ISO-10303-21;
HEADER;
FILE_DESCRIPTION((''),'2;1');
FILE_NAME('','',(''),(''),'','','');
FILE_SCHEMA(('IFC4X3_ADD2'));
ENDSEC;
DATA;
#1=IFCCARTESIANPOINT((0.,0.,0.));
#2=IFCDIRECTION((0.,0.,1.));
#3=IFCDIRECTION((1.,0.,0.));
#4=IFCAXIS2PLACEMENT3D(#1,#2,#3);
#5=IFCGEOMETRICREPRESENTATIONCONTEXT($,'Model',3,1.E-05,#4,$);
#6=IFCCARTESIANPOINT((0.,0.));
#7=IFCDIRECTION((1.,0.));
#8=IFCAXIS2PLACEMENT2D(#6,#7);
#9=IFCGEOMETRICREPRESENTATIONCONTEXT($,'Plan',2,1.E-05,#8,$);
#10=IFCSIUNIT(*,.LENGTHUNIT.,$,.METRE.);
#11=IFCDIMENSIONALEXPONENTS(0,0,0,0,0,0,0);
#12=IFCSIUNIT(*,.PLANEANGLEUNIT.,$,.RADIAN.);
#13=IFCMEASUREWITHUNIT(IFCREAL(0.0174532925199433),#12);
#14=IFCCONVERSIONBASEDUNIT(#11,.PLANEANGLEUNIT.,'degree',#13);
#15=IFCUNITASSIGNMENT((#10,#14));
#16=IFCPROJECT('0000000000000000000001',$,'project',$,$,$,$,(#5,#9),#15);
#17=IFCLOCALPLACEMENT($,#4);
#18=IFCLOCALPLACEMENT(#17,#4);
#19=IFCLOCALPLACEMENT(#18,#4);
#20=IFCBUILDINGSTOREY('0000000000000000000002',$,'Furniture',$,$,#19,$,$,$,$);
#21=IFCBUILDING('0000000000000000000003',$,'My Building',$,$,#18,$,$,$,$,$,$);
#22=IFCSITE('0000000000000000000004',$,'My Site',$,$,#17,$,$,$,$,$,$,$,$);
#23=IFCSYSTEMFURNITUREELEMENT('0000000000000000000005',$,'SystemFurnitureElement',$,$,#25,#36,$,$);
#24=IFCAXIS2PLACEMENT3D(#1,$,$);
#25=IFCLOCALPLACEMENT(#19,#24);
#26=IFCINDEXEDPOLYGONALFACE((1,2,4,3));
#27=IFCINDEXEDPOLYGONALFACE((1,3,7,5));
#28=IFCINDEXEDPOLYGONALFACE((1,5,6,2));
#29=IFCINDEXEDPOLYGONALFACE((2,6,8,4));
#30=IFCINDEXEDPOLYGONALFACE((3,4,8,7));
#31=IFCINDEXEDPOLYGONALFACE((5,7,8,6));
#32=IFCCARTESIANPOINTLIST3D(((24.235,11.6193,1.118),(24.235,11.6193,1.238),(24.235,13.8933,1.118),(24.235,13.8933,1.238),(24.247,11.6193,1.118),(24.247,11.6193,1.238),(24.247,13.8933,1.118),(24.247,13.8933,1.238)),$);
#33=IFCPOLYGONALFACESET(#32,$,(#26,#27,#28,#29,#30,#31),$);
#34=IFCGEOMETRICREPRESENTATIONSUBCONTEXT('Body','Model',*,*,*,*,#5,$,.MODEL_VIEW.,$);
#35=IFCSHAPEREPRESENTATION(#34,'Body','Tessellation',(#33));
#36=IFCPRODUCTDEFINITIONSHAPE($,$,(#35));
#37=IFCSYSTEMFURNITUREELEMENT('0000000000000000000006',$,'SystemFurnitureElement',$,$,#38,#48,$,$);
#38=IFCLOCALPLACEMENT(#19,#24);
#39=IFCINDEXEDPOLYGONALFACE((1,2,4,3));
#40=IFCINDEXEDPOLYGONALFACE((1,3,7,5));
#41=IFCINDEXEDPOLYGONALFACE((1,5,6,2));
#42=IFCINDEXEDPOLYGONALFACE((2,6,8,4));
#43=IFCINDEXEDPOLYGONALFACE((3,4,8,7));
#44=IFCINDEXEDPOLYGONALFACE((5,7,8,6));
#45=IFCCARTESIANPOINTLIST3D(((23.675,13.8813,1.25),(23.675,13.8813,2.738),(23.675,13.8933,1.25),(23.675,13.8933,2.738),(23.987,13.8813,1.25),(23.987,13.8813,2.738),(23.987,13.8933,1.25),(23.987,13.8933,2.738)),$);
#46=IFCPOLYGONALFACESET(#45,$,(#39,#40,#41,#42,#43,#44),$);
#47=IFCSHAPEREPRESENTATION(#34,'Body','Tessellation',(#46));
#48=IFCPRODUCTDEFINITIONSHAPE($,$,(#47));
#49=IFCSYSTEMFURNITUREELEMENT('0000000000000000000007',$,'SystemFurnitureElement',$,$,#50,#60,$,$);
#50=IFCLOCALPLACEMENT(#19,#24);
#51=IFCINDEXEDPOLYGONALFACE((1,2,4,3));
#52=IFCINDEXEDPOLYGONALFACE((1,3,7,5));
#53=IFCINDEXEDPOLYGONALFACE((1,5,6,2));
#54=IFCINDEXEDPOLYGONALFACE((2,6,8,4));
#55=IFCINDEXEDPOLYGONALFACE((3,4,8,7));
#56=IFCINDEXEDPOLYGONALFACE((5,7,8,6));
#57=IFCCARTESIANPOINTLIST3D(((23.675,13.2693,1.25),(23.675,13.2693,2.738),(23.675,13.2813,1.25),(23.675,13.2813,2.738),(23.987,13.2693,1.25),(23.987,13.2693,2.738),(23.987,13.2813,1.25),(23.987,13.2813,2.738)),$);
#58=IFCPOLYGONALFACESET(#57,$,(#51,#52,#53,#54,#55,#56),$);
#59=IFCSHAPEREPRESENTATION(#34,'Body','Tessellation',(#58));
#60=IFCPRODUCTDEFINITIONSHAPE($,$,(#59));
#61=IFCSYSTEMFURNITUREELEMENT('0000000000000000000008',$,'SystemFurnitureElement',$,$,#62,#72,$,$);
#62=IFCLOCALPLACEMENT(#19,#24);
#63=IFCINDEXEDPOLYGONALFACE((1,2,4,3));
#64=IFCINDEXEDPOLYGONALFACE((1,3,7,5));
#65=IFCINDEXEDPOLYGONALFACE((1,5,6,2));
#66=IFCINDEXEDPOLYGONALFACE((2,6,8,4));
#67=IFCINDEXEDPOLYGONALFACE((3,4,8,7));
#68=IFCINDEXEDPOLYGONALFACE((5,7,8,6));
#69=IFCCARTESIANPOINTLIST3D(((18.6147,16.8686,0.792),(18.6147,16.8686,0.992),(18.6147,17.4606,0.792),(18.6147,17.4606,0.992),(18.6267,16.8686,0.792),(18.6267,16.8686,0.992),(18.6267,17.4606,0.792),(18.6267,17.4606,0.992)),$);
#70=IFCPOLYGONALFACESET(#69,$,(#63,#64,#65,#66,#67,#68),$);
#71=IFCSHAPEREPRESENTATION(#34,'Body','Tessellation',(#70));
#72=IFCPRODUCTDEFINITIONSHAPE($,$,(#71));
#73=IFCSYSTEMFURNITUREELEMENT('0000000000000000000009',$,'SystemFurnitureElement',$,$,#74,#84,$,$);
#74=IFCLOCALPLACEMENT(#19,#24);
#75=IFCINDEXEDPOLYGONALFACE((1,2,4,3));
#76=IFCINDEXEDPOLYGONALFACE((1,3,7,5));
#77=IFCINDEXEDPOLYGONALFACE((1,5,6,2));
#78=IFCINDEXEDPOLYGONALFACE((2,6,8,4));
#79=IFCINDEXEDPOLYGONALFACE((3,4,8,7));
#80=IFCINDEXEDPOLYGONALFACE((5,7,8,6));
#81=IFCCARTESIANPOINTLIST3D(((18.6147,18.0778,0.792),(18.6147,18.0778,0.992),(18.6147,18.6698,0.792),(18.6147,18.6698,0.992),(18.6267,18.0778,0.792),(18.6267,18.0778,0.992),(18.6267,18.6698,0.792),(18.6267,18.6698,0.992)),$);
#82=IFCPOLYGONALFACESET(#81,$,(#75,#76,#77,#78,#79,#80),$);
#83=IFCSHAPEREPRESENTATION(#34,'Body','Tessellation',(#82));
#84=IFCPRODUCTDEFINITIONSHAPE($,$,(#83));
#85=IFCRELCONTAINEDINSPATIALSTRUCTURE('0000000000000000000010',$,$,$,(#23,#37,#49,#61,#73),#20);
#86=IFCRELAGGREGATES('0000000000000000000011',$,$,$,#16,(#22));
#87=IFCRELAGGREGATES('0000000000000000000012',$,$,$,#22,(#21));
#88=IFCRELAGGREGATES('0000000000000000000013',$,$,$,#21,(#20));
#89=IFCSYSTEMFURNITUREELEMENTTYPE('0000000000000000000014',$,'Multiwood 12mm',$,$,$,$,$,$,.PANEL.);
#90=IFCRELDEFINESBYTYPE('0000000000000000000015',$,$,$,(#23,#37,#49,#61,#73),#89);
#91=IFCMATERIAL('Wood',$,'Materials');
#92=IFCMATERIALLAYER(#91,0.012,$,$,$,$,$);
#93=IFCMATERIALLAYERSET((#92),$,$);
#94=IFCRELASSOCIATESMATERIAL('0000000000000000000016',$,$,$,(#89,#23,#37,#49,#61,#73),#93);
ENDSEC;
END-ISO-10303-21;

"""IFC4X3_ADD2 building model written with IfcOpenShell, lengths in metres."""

from ifc_helpers import new_model, entity, si_unit, converted_unit, frame, origin_with_axes, origin_2d_with_axis, place, context, subcontext, project, spatial, line, indexed_curve, outline, extrude, material, layer, layer_set, layer_usage, type_object, element, save


model = new_model("IFC4X3_ADD2")

# Units and contexts
model_context = context("Model", 3, precision=1e-05, world=origin_with_axes())
plan_context = context("Plan", 2, precision=1e-05, world=origin_2d_with_axis())
body_context = subcontext(model_context, "Body", "Model", "MODEL_VIEW")
ifc_project = project(units=[si_unit("LENGTHUNIT", "METRE"), converted_unit("PLANEANGLEUNIT", "degree", entity("IfcReal", 0.0174532925199433), si_unit("PLANEANGLEUNIT", "RADIAN"), dimensions=[0, 0, 0, 0, 0, 0, 0])], contexts=[model_context, plan_context])

# Site, building, storey
site_placement = place(None, origin_with_axes())
site = spatial("IfcSite", under=ifc_project, at=site_placement, Name="My Site")
building_placement = place(site_placement, origin_with_axes())
building = spatial("IfcBuilding", under=site, at=building_placement, Name="My Building")
storey_placement = place(building_placement, origin_with_axes())
storey = spatial("IfcBuildingStorey", under=building, at=storey_placement, Name="Furniture")

# System furniture elements
ifc_material = material(Name="Wood", Category="Materials")
ifc_layer_1 = layer(ifc_material, 0.012)
ifc_layer_set_1 = layer_set([ifc_layer_1])
ifc_layer_usage_1 = layer_usage(ifc_layer_set_1, "AXIS2", "POSITIVE", 0.0)
system_furniture_element_type_1 = type_object("IfcSystemFurnitureElementType", Name="Multiwood 12mm", PredefinedType="PANEL", material=ifc_layer_set_1)
system_furniture_element_1_placement = place(storey_placement, frame((24.247, 11.6193, 1.118), z_axis=(0.0, 0.0, 1.0), x_axis=(0.000001, 1.0, 0.0)))
element("IfcSystemFurnitureElement", 1, at=system_furniture_element_1_placement, inside=storey, type_object=system_furniture_element_type_1, material=ifc_layer_usage_1, Name="SystemFurnitureElement", context=body_context, shape_type="SweptSolid", body=[
    extrude(outline(indexed_curve([(0.0, 0.0), (0.0, 0.012), (2.274, 0.012), (2.274, 0.0)], segments=[line(1, 2, 3, 4, 1)])), origin_with_axes(), (0.0, 0.0, 1.0), 0.12),
])
ifc_layer_usage_2 = layer_usage(ifc_layer_set_1, "AXIS2", "POSITIVE", 0.0)
system_furniture_element_2_placement = place(storey_placement, frame((23.675, 13.8813, 1.25), z_axis=(0.0, 0.0, 1.0), x_axis=(1.0, -0.000001, 0.0)))
element("IfcSystemFurnitureElement", 2, at=system_furniture_element_2_placement, inside=storey, type_object=system_furniture_element_type_1, material=ifc_layer_usage_2, Name="SystemFurnitureElement", context=body_context, shape_type="SweptSolid", body=[
    extrude(outline(indexed_curve([(0.0, 0.0), (0.0, 0.012), (0.312, 0.012), (0.312, 0.0)], segments=[line(1, 2, 3, 4, 1)])), origin_with_axes(), (0.0, 0.0, 1.0), 1.488),
])
ifc_layer_usage_3 = layer_usage(ifc_layer_set_1, "AXIS2", "POSITIVE", 0.0)
system_furniture_element_3_placement = place(storey_placement, frame((23.675, 13.2693, 1.25), z_axis=(0.0, 0.0, 1.0), x_axis=(1.0, -0.000001, 0.0)))
element("IfcSystemFurnitureElement", 3, at=system_furniture_element_3_placement, inside=storey, type_object=system_furniture_element_type_1, material=ifc_layer_usage_3, Name="SystemFurnitureElement", context=body_context, shape_type="SweptSolid", body=[
    extrude(outline(indexed_curve([(0.0, 0.0), (0.0, 0.012), (0.312, 0.012), (0.312, 0.0)], segments=[line(1, 2, 3, 4, 1)])), origin_with_axes(), (0.0, 0.0, 1.0), 1.488),
])
ifc_layer_usage_4 = layer_usage(ifc_layer_set_1, "AXIS2", "POSITIVE", 0.0)
system_furniture_element_4_placement = place(storey_placement, frame((18.6267, 16.8686, 0.792), z_axis=(0.0, 0.0, 1.0), x_axis=(0.000001, 1.0, 0.0)))
element("IfcSystemFurnitureElement", 4, at=system_furniture_element_4_placement, inside=storey, type_object=system_furniture_element_type_1, material=ifc_layer_usage_4, Name="SystemFurnitureElement", context=body_context, shape_type="SweptSolid", body=[
    extrude(outline(indexed_curve([(0.0, 0.0), (0.0, 0.012), (0.592, 0.012), (0.592, 0.0)], segments=[line(1, 2, 3, 4, 1)])), origin_with_axes(), (0.0, 0.0, 1.0), 0.2),
])
ifc_layer_usage_5 = layer_usage(ifc_layer_set_1, "AXIS2", "POSITIVE", 0.0)
system_furniture_element_5_placement = place(storey_placement, frame((18.6267, 18.0778, 0.792), z_axis=(0.0, 0.0, 1.0), x_axis=(0.000001, 1.0, 0.0)))
element("IfcSystemFurnitureElement", 5, at=system_furniture_element_5_placement, inside=storey, type_object=system_furniture_element_type_1, material=ifc_layer_usage_5, Name="SystemFurnitureElement", context=body_context, shape_type="SweptSolid", body=[
    extrude(outline(indexed_curve([(0.0, 0.0), (0.0, 0.012), (0.592, 0.012), (0.592, 0.0)], segments=[line(1, 2, 3, 4, 1)])), origin_with_axes(), (0.0, 0.0, 1.0), 0.2),
])

save(model, "model.ifc")
